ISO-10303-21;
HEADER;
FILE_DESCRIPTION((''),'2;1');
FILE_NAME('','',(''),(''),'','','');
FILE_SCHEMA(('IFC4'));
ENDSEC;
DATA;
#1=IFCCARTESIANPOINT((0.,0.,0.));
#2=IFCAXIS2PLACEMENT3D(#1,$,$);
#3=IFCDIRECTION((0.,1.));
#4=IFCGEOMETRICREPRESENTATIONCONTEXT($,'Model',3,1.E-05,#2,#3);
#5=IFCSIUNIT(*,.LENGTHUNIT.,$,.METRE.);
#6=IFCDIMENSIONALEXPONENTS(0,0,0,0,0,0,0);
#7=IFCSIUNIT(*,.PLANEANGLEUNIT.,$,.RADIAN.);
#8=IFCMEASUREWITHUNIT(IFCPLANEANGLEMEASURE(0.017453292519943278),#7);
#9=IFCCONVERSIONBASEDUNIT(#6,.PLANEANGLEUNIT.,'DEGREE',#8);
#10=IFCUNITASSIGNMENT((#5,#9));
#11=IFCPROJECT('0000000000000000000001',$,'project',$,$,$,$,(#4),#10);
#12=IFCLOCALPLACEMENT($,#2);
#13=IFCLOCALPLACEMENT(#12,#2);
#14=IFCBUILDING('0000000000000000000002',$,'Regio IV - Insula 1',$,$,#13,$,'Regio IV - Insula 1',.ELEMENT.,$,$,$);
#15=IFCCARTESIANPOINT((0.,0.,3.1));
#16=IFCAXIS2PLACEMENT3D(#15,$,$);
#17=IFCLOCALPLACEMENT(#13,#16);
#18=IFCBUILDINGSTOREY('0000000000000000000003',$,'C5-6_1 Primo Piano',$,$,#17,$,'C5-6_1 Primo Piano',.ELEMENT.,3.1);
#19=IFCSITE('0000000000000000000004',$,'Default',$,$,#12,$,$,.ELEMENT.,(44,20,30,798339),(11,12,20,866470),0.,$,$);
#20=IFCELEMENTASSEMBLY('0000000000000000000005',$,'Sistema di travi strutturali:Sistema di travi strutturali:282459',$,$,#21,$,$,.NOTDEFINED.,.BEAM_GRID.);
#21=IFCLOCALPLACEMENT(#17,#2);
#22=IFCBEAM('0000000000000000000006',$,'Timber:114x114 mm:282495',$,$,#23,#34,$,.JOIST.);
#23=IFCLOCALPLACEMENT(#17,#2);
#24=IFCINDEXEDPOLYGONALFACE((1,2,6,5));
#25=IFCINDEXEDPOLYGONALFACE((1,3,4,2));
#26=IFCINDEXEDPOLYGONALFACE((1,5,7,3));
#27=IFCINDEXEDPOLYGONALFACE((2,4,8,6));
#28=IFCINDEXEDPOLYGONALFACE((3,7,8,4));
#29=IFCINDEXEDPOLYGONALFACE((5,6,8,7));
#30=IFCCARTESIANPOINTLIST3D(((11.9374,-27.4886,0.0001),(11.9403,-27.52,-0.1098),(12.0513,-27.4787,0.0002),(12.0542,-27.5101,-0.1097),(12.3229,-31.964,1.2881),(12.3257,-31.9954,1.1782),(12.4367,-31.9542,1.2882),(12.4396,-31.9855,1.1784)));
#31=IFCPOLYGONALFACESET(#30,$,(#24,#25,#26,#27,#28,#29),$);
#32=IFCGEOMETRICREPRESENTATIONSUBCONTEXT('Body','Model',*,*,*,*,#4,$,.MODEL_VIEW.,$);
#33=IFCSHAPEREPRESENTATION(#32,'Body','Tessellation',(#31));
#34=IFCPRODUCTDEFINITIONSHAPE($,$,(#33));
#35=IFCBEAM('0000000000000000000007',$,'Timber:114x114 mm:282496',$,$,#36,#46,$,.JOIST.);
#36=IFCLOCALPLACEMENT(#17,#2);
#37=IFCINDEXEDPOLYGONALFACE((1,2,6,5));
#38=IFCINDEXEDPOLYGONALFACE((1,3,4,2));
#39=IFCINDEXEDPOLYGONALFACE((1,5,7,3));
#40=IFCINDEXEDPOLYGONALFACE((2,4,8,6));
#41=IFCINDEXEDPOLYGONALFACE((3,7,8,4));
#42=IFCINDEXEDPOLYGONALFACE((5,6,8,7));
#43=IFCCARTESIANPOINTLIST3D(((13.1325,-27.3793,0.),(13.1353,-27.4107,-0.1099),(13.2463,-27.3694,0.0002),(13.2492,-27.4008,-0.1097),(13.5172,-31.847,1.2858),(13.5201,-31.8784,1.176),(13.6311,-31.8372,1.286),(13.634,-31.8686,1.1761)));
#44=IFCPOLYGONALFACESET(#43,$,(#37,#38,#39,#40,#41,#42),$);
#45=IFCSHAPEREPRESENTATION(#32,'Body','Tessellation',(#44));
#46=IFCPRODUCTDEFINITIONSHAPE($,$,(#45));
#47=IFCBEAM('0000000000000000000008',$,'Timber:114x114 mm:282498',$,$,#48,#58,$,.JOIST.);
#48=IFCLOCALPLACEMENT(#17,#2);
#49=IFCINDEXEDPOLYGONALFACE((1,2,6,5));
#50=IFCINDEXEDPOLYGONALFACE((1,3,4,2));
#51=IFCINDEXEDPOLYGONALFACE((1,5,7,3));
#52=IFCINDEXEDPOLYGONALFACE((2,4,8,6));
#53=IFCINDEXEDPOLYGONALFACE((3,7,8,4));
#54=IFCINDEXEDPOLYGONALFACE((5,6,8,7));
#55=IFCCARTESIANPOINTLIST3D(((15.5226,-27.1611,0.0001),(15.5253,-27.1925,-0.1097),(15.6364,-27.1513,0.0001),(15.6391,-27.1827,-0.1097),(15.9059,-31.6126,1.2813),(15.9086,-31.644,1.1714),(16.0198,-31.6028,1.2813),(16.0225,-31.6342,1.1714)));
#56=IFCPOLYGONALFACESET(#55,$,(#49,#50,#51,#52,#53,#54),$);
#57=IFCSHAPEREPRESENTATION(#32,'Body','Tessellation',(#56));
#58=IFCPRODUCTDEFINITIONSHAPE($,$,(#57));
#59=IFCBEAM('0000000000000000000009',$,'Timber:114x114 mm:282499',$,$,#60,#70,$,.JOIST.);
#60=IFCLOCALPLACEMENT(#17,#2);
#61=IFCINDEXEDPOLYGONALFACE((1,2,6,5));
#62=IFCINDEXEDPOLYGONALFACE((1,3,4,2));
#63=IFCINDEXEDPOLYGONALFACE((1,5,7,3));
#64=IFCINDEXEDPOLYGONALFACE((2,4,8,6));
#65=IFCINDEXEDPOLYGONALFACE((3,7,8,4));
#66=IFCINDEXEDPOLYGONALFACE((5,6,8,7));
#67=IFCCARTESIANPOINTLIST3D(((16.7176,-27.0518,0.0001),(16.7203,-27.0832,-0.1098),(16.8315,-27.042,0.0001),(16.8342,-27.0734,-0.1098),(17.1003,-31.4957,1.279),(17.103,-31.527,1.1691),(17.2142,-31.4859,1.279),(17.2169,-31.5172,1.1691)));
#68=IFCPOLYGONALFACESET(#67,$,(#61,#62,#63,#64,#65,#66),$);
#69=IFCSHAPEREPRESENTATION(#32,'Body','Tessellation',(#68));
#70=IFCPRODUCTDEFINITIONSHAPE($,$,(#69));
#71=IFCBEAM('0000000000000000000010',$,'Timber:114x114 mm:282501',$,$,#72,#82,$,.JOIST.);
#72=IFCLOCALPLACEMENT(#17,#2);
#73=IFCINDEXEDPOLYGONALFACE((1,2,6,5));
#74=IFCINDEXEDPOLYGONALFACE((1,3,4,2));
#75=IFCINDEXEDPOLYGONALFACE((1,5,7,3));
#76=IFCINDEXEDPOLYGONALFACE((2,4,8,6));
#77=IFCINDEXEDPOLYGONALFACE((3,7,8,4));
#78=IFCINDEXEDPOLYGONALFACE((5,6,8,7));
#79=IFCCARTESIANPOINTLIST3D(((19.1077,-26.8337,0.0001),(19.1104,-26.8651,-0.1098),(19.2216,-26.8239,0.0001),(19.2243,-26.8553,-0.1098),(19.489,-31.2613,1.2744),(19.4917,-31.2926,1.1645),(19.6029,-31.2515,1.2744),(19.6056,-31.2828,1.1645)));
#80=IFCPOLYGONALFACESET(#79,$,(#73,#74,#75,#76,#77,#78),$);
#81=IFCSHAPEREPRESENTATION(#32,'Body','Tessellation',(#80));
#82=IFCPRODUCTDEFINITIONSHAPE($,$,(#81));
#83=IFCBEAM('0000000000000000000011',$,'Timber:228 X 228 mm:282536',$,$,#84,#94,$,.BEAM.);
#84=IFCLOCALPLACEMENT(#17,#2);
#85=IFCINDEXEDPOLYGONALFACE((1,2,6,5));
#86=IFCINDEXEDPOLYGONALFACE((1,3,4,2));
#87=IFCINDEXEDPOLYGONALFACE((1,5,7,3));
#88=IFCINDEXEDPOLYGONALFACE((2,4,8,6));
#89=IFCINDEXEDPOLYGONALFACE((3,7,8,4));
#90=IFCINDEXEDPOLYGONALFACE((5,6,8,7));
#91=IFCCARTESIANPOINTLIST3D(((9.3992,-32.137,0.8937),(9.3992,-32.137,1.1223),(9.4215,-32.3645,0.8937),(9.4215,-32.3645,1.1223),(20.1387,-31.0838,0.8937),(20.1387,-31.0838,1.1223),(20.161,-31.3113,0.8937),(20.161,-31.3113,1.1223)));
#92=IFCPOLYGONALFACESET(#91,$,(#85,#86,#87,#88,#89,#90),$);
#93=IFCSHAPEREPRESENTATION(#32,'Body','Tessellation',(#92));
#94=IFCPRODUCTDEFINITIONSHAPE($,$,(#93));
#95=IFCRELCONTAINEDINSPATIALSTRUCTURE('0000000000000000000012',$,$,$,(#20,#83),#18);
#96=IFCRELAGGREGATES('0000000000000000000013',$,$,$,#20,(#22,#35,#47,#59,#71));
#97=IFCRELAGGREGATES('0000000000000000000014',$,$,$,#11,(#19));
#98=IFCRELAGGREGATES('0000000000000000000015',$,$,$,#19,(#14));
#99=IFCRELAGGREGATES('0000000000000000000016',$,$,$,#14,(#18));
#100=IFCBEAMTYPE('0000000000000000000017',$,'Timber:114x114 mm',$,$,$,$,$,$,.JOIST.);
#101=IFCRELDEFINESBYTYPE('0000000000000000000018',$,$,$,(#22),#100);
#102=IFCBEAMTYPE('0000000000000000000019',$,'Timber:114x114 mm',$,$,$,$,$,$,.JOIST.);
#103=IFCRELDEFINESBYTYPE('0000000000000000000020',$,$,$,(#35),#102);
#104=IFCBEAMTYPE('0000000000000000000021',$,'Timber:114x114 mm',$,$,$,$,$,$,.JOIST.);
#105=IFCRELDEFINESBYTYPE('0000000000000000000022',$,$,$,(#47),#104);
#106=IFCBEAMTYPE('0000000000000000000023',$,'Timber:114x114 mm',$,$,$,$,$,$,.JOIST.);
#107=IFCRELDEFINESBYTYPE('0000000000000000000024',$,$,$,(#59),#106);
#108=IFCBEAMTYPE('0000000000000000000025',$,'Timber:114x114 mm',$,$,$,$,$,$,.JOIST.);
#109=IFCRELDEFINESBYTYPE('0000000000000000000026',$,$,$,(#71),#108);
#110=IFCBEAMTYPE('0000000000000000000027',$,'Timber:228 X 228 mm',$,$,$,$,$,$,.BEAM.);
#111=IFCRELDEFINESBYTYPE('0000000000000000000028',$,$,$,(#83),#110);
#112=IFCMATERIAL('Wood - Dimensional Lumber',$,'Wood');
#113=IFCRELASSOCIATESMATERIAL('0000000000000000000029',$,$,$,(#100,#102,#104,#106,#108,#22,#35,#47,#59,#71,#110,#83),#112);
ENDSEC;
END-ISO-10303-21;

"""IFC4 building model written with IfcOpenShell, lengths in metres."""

from ifc_helpers import new_model, entity, si_unit, converted_unit, direction, frame, frame_2d, origin, origin_2d_with_axis, place, context, subcontext, project, spatial, rectangle, extrude, source, transform, mapped, material, material_profile, profile_set, profile_usage, type_object, type_shapes, element, aggregate, save


model = new_model("IFC4")

# Units and contexts
model_context = context("Model", 3, precision=1e-05, world=origin(), true_north=direction((0.0, 1.0)))
body_context = subcontext(model_context, "Body", "Model", "MODEL_VIEW")
ifc_project = project(units=[si_unit("LENGTHUNIT", "METRE"), converted_unit("PLANEANGLEUNIT", "DEGREE", entity("IfcPlaneAngleMeasure", 0.017453292519943278), si_unit("PLANEANGLEUNIT", "RADIAN"), dimensions=[0, 0, 0, 0, 0, 0, 0])], contexts=[model_context])

# Site, building, storey
site_placement = place(None, origin())
site = spatial("IfcSite", under=ifc_project, at=site_placement, Name="Default", CompositionType="ELEMENT", RefLatitude=(44, 20, 30, 798339), RefLongitude=(11, 12, 20, 866470), RefElevation=0.0)
building_placement = place(site_placement, origin())
building = spatial("IfcBuilding", under=site, at=building_placement, Name="Regio IV - Insula 1", LongName="Regio IV - Insula 1", CompositionType="ELEMENT")
storey_placement = place(building_placement, frame((0.0, 0.0, 3.1)))
storey = spatial("IfcBuildingStorey", under=building, at=storey_placement, Name="C5-6_1 Primo Piano", LongName="C5-6_1 Primo Piano", CompositionType="ELEMENT", Elevation=3.1)

# Shared definitions
ifc_material = material(Name="Wood - Dimensional Lumber", Category="Wood")
ifc_material_profile_1 = material_profile(ifc_material, rectangle(XDim=5.294, YDim=0.1143, at=origin_2d_with_axis()), Name="114x114 mm")
ifc_profile_set_1 = profile_set([ifc_material_profile_1], Name="114x114 mm")
ifc_profile_usage_1 = profile_usage(ifc_profile_set_1, cardinal=8)

# Shared definitions
ifc_material_profile_2 = material_profile(ifc_material, rectangle(XDim=8.091, YDim=0.2286, at=frame_2d((0.0, 0.0), x_axis=(1.0, 0.0))), Name="228 X 228 mm")
ifc_profile_set_2 = profile_set([ifc_material_profile_2], Name="228 X 228 mm")
ifc_profile_usage_2 = profile_usage(ifc_profile_set_2, cardinal=1)

# Element assembly
assembly_1_placement = place(storey_placement, origin())
assembly_1 = element("IfcElementAssembly", 1, at=assembly_1_placement, inside=storey, Name="Sistema di travi strutturali:Sistema di travi strutturali:282459", AssemblyPlace="NOTDEFINED", PredefinedType="BEAM_GRID")

# Beams
beam_type_1 = type_object("IfcBeamType", Name="Timber:114x114 mm", PredefinedType="JOIST", material=ifc_profile_set_1)
shared_shape_1 = source(origin(), body_context, "Body", "SweptSolid", [
    extrude(rectangle(XDim=4.673, YDim=0.1143, at=origin_2d_with_axis()), frame((0.0, 0.0, -0.0572), z_axis=(0.0, 0.0, 1.0), x_axis=(-1.0, 0.0, 0.0)), (0.0, 0.0, 1.0), 0.1143),
])
type_shapes(beam_type_1, [shared_shape_1])
beam_1_placement = place(assembly_1_placement, frame((12.1885, -29.7371, 0.5892), z_axis=(-0.025067, 0.274495, 0.961262), x_axis=(0.082477, -0.957718, 0.275634)))
beam_1 = element("IfcBeam", 2, at=beam_1_placement, type_object=beam_type_1, material=ifc_profile_usage_1, Name="Timber:114x114 mm:282495", PredefinedType="JOIST", context=body_context, shape_type="MappedRepresentation", body=[
    mapped(shared_shape_1, transform((0.0, 0.0, 0.0), scale=1.0)),
])
beam_type_2 = type_object("IfcBeamType", Name="Timber:114x114 mm", PredefinedType="JOIST", material=ifc_profile_set_1)
shared_shape_2 = source(origin(), body_context, "Body", "SweptSolid", [
    extrude(rectangle(XDim=4.665, YDim=0.1143, at=origin_2d_with_axis()), frame((0.0, 0.0, -0.0572), z_axis=(0.0, 0.0, 1.0), x_axis=(-1.0, 0.0, 0.0)), (0.0, 0.0, 1.0), 0.1143),
])
type_shapes(beam_type_2, [shared_shape_2])
beam_2_placement = place(assembly_1_placement, frame((13.3832, -29.6239, 0.5881), z_axis=(-0.025067, 0.274495, 0.961262), x_axis=(0.082477, -0.957718, 0.275634)))
beam_2 = element("IfcBeam", 3, at=beam_2_placement, type_object=beam_type_2, material=ifc_profile_usage_1, Name="Timber:114x114 mm:282496", PredefinedType="JOIST", context=body_context, shape_type="MappedRepresentation", body=[
    mapped(shared_shape_2, transform((0.0, 0.0, 0.0), scale=1.0)),
])
beam_type_3 = type_object("IfcBeamType", Name="Timber:114x114 mm", PredefinedType="JOIST", material=ifc_profile_set_1)
shared_shape_3 = source(origin(), body_context, "Body", "SweptSolid", [
    extrude(rectangle(XDim=4.648, YDim=0.1143, at=origin_2d_with_axis()), frame((0.0, 0.0, -0.0572), z_axis=(0.0, 0.0, 1.0), x_axis=(-1.0, 0.0, 0.0)), (0.0, 0.0, 1.0), 0.1143),
])
type_shapes(beam_type_3, [shared_shape_3])
beam_3_placement = place(assembly_1_placement, frame((15.7725, -29.3977, 0.5858), z_axis=(-0.02365, 0.274618, 0.961263), x_axis=(0.082477, -0.957718, 0.275634)))
beam_3 = element("IfcBeam", 4, at=beam_3_placement, type_object=beam_type_3, material=ifc_profile_usage_1, Name="Timber:114x114 mm:282498", PredefinedType="JOIST", context=body_context, shape_type="MappedRepresentation", body=[
    mapped(shared_shape_3, transform((0.0, 0.0, 0.0), scale=1.0)),
])
beam_type_4 = type_object("IfcBeamType", Name="Timber:114x114 mm", PredefinedType="JOIST", material=ifc_profile_set_1)
shared_shape_4 = source(origin(), body_context, "Body", "SweptSolid", [
    extrude(rectangle(XDim=4.64, YDim=0.1143, at=origin_2d_with_axis()), frame((0.0, 0.0, -0.0572), z_axis=(0.0, 0.0, 1.0), x_axis=(-1.0, 0.0, 0.0)), (0.0, 0.0, 1.0), 0.1143),
])
type_shapes(beam_type_4, [shared_shape_4])
beam_4_placement = place(assembly_1_placement, frame((16.9672, -29.2845, 0.5846), z_axis=(-0.02365, 0.274618, 0.961263), x_axis=(0.082477, -0.957718, 0.275634)))
beam_4 = element("IfcBeam", 5, at=beam_4_placement, type_object=beam_type_4, material=ifc_profile_usage_1, Name="Timber:114x114 mm:282499", PredefinedType="JOIST", context=body_context, shape_type="MappedRepresentation", body=[
    mapped(shared_shape_4, transform((0.0, 0.0, 0.0), scale=1.0)),
])
beam_type_5 = type_object("IfcBeamType", Name="Timber:114x114 mm", PredefinedType="JOIST", material=ifc_profile_set_1)
shared_shape_5 = source(origin(), body_context, "Body", "SweptSolid", [
    extrude(rectangle(XDim=4.623, YDim=0.1143, at=origin_2d_with_axis()), frame((0.0, 0.0, -0.0572), z_axis=(0.0, 0.0, 1.0), x_axis=(-1.0, 0.0, 0.0)), (0.0, 0.0, 1.0), 0.1143),
])
type_shapes(beam_type_5, [shared_shape_5])
beam_5_placement = place(assembly_1_placement, frame((19.3566, -29.0583, 0.5823), z_axis=(-0.02365, 0.274618, 0.961263), x_axis=(0.082477, -0.957718, 0.275634)))
beam_5 = element("IfcBeam", 6, at=beam_5_placement, type_object=beam_type_5, material=ifc_profile_usage_1, Name="Timber:114x114 mm:282501", PredefinedType="JOIST", context=body_context, shape_type="MappedRepresentation", body=[
    mapped(shared_shape_5, transform((0.0, 0.0, 0.0), scale=1.0)),
])
aggregate(assembly_1, [beam_1, beam_2, beam_3, beam_4, beam_5])
beam_type_6 = type_object("IfcBeamType", Name="Timber:228 X 228 mm", PredefinedType="BEAM", material=ifc_profile_set_2)
shared_shape_6 = source(origin(), body_context, "Body", "SweptSolid", [
    extrude(rectangle(XDim=10.791, YDim=0.2286, at=origin_2d_with_axis()), frame((0.0, 0.0, -0.1143), z_axis=(0.0, 0.0, 1.0), x_axis=(-1.0, 0.0, 0.0)), (0.0, 0.0, 1.0), 0.2286),
])
type_shapes(beam_type_6, [shared_shape_6])
beam_6_placement = place(storey_placement, frame((14.7801, -31.7241, 1.008), z_axis=(-0.000003, 0.0, 1.0), x_axis=(-0.995226, -0.097601, -0.000003)))
element("IfcBeam", 7, at=beam_6_placement, inside=storey, type_object=beam_type_6, material=ifc_profile_usage_2, Name="Timber:228 X 228 mm:282536", PredefinedType="BEAM", context=body_context, shape_type="MappedRepresentation", body=[
    mapped(shared_shape_6, transform((0.0, 0.0, 0.0), scale=1.0)),
])

save(model, "model.ifc")
